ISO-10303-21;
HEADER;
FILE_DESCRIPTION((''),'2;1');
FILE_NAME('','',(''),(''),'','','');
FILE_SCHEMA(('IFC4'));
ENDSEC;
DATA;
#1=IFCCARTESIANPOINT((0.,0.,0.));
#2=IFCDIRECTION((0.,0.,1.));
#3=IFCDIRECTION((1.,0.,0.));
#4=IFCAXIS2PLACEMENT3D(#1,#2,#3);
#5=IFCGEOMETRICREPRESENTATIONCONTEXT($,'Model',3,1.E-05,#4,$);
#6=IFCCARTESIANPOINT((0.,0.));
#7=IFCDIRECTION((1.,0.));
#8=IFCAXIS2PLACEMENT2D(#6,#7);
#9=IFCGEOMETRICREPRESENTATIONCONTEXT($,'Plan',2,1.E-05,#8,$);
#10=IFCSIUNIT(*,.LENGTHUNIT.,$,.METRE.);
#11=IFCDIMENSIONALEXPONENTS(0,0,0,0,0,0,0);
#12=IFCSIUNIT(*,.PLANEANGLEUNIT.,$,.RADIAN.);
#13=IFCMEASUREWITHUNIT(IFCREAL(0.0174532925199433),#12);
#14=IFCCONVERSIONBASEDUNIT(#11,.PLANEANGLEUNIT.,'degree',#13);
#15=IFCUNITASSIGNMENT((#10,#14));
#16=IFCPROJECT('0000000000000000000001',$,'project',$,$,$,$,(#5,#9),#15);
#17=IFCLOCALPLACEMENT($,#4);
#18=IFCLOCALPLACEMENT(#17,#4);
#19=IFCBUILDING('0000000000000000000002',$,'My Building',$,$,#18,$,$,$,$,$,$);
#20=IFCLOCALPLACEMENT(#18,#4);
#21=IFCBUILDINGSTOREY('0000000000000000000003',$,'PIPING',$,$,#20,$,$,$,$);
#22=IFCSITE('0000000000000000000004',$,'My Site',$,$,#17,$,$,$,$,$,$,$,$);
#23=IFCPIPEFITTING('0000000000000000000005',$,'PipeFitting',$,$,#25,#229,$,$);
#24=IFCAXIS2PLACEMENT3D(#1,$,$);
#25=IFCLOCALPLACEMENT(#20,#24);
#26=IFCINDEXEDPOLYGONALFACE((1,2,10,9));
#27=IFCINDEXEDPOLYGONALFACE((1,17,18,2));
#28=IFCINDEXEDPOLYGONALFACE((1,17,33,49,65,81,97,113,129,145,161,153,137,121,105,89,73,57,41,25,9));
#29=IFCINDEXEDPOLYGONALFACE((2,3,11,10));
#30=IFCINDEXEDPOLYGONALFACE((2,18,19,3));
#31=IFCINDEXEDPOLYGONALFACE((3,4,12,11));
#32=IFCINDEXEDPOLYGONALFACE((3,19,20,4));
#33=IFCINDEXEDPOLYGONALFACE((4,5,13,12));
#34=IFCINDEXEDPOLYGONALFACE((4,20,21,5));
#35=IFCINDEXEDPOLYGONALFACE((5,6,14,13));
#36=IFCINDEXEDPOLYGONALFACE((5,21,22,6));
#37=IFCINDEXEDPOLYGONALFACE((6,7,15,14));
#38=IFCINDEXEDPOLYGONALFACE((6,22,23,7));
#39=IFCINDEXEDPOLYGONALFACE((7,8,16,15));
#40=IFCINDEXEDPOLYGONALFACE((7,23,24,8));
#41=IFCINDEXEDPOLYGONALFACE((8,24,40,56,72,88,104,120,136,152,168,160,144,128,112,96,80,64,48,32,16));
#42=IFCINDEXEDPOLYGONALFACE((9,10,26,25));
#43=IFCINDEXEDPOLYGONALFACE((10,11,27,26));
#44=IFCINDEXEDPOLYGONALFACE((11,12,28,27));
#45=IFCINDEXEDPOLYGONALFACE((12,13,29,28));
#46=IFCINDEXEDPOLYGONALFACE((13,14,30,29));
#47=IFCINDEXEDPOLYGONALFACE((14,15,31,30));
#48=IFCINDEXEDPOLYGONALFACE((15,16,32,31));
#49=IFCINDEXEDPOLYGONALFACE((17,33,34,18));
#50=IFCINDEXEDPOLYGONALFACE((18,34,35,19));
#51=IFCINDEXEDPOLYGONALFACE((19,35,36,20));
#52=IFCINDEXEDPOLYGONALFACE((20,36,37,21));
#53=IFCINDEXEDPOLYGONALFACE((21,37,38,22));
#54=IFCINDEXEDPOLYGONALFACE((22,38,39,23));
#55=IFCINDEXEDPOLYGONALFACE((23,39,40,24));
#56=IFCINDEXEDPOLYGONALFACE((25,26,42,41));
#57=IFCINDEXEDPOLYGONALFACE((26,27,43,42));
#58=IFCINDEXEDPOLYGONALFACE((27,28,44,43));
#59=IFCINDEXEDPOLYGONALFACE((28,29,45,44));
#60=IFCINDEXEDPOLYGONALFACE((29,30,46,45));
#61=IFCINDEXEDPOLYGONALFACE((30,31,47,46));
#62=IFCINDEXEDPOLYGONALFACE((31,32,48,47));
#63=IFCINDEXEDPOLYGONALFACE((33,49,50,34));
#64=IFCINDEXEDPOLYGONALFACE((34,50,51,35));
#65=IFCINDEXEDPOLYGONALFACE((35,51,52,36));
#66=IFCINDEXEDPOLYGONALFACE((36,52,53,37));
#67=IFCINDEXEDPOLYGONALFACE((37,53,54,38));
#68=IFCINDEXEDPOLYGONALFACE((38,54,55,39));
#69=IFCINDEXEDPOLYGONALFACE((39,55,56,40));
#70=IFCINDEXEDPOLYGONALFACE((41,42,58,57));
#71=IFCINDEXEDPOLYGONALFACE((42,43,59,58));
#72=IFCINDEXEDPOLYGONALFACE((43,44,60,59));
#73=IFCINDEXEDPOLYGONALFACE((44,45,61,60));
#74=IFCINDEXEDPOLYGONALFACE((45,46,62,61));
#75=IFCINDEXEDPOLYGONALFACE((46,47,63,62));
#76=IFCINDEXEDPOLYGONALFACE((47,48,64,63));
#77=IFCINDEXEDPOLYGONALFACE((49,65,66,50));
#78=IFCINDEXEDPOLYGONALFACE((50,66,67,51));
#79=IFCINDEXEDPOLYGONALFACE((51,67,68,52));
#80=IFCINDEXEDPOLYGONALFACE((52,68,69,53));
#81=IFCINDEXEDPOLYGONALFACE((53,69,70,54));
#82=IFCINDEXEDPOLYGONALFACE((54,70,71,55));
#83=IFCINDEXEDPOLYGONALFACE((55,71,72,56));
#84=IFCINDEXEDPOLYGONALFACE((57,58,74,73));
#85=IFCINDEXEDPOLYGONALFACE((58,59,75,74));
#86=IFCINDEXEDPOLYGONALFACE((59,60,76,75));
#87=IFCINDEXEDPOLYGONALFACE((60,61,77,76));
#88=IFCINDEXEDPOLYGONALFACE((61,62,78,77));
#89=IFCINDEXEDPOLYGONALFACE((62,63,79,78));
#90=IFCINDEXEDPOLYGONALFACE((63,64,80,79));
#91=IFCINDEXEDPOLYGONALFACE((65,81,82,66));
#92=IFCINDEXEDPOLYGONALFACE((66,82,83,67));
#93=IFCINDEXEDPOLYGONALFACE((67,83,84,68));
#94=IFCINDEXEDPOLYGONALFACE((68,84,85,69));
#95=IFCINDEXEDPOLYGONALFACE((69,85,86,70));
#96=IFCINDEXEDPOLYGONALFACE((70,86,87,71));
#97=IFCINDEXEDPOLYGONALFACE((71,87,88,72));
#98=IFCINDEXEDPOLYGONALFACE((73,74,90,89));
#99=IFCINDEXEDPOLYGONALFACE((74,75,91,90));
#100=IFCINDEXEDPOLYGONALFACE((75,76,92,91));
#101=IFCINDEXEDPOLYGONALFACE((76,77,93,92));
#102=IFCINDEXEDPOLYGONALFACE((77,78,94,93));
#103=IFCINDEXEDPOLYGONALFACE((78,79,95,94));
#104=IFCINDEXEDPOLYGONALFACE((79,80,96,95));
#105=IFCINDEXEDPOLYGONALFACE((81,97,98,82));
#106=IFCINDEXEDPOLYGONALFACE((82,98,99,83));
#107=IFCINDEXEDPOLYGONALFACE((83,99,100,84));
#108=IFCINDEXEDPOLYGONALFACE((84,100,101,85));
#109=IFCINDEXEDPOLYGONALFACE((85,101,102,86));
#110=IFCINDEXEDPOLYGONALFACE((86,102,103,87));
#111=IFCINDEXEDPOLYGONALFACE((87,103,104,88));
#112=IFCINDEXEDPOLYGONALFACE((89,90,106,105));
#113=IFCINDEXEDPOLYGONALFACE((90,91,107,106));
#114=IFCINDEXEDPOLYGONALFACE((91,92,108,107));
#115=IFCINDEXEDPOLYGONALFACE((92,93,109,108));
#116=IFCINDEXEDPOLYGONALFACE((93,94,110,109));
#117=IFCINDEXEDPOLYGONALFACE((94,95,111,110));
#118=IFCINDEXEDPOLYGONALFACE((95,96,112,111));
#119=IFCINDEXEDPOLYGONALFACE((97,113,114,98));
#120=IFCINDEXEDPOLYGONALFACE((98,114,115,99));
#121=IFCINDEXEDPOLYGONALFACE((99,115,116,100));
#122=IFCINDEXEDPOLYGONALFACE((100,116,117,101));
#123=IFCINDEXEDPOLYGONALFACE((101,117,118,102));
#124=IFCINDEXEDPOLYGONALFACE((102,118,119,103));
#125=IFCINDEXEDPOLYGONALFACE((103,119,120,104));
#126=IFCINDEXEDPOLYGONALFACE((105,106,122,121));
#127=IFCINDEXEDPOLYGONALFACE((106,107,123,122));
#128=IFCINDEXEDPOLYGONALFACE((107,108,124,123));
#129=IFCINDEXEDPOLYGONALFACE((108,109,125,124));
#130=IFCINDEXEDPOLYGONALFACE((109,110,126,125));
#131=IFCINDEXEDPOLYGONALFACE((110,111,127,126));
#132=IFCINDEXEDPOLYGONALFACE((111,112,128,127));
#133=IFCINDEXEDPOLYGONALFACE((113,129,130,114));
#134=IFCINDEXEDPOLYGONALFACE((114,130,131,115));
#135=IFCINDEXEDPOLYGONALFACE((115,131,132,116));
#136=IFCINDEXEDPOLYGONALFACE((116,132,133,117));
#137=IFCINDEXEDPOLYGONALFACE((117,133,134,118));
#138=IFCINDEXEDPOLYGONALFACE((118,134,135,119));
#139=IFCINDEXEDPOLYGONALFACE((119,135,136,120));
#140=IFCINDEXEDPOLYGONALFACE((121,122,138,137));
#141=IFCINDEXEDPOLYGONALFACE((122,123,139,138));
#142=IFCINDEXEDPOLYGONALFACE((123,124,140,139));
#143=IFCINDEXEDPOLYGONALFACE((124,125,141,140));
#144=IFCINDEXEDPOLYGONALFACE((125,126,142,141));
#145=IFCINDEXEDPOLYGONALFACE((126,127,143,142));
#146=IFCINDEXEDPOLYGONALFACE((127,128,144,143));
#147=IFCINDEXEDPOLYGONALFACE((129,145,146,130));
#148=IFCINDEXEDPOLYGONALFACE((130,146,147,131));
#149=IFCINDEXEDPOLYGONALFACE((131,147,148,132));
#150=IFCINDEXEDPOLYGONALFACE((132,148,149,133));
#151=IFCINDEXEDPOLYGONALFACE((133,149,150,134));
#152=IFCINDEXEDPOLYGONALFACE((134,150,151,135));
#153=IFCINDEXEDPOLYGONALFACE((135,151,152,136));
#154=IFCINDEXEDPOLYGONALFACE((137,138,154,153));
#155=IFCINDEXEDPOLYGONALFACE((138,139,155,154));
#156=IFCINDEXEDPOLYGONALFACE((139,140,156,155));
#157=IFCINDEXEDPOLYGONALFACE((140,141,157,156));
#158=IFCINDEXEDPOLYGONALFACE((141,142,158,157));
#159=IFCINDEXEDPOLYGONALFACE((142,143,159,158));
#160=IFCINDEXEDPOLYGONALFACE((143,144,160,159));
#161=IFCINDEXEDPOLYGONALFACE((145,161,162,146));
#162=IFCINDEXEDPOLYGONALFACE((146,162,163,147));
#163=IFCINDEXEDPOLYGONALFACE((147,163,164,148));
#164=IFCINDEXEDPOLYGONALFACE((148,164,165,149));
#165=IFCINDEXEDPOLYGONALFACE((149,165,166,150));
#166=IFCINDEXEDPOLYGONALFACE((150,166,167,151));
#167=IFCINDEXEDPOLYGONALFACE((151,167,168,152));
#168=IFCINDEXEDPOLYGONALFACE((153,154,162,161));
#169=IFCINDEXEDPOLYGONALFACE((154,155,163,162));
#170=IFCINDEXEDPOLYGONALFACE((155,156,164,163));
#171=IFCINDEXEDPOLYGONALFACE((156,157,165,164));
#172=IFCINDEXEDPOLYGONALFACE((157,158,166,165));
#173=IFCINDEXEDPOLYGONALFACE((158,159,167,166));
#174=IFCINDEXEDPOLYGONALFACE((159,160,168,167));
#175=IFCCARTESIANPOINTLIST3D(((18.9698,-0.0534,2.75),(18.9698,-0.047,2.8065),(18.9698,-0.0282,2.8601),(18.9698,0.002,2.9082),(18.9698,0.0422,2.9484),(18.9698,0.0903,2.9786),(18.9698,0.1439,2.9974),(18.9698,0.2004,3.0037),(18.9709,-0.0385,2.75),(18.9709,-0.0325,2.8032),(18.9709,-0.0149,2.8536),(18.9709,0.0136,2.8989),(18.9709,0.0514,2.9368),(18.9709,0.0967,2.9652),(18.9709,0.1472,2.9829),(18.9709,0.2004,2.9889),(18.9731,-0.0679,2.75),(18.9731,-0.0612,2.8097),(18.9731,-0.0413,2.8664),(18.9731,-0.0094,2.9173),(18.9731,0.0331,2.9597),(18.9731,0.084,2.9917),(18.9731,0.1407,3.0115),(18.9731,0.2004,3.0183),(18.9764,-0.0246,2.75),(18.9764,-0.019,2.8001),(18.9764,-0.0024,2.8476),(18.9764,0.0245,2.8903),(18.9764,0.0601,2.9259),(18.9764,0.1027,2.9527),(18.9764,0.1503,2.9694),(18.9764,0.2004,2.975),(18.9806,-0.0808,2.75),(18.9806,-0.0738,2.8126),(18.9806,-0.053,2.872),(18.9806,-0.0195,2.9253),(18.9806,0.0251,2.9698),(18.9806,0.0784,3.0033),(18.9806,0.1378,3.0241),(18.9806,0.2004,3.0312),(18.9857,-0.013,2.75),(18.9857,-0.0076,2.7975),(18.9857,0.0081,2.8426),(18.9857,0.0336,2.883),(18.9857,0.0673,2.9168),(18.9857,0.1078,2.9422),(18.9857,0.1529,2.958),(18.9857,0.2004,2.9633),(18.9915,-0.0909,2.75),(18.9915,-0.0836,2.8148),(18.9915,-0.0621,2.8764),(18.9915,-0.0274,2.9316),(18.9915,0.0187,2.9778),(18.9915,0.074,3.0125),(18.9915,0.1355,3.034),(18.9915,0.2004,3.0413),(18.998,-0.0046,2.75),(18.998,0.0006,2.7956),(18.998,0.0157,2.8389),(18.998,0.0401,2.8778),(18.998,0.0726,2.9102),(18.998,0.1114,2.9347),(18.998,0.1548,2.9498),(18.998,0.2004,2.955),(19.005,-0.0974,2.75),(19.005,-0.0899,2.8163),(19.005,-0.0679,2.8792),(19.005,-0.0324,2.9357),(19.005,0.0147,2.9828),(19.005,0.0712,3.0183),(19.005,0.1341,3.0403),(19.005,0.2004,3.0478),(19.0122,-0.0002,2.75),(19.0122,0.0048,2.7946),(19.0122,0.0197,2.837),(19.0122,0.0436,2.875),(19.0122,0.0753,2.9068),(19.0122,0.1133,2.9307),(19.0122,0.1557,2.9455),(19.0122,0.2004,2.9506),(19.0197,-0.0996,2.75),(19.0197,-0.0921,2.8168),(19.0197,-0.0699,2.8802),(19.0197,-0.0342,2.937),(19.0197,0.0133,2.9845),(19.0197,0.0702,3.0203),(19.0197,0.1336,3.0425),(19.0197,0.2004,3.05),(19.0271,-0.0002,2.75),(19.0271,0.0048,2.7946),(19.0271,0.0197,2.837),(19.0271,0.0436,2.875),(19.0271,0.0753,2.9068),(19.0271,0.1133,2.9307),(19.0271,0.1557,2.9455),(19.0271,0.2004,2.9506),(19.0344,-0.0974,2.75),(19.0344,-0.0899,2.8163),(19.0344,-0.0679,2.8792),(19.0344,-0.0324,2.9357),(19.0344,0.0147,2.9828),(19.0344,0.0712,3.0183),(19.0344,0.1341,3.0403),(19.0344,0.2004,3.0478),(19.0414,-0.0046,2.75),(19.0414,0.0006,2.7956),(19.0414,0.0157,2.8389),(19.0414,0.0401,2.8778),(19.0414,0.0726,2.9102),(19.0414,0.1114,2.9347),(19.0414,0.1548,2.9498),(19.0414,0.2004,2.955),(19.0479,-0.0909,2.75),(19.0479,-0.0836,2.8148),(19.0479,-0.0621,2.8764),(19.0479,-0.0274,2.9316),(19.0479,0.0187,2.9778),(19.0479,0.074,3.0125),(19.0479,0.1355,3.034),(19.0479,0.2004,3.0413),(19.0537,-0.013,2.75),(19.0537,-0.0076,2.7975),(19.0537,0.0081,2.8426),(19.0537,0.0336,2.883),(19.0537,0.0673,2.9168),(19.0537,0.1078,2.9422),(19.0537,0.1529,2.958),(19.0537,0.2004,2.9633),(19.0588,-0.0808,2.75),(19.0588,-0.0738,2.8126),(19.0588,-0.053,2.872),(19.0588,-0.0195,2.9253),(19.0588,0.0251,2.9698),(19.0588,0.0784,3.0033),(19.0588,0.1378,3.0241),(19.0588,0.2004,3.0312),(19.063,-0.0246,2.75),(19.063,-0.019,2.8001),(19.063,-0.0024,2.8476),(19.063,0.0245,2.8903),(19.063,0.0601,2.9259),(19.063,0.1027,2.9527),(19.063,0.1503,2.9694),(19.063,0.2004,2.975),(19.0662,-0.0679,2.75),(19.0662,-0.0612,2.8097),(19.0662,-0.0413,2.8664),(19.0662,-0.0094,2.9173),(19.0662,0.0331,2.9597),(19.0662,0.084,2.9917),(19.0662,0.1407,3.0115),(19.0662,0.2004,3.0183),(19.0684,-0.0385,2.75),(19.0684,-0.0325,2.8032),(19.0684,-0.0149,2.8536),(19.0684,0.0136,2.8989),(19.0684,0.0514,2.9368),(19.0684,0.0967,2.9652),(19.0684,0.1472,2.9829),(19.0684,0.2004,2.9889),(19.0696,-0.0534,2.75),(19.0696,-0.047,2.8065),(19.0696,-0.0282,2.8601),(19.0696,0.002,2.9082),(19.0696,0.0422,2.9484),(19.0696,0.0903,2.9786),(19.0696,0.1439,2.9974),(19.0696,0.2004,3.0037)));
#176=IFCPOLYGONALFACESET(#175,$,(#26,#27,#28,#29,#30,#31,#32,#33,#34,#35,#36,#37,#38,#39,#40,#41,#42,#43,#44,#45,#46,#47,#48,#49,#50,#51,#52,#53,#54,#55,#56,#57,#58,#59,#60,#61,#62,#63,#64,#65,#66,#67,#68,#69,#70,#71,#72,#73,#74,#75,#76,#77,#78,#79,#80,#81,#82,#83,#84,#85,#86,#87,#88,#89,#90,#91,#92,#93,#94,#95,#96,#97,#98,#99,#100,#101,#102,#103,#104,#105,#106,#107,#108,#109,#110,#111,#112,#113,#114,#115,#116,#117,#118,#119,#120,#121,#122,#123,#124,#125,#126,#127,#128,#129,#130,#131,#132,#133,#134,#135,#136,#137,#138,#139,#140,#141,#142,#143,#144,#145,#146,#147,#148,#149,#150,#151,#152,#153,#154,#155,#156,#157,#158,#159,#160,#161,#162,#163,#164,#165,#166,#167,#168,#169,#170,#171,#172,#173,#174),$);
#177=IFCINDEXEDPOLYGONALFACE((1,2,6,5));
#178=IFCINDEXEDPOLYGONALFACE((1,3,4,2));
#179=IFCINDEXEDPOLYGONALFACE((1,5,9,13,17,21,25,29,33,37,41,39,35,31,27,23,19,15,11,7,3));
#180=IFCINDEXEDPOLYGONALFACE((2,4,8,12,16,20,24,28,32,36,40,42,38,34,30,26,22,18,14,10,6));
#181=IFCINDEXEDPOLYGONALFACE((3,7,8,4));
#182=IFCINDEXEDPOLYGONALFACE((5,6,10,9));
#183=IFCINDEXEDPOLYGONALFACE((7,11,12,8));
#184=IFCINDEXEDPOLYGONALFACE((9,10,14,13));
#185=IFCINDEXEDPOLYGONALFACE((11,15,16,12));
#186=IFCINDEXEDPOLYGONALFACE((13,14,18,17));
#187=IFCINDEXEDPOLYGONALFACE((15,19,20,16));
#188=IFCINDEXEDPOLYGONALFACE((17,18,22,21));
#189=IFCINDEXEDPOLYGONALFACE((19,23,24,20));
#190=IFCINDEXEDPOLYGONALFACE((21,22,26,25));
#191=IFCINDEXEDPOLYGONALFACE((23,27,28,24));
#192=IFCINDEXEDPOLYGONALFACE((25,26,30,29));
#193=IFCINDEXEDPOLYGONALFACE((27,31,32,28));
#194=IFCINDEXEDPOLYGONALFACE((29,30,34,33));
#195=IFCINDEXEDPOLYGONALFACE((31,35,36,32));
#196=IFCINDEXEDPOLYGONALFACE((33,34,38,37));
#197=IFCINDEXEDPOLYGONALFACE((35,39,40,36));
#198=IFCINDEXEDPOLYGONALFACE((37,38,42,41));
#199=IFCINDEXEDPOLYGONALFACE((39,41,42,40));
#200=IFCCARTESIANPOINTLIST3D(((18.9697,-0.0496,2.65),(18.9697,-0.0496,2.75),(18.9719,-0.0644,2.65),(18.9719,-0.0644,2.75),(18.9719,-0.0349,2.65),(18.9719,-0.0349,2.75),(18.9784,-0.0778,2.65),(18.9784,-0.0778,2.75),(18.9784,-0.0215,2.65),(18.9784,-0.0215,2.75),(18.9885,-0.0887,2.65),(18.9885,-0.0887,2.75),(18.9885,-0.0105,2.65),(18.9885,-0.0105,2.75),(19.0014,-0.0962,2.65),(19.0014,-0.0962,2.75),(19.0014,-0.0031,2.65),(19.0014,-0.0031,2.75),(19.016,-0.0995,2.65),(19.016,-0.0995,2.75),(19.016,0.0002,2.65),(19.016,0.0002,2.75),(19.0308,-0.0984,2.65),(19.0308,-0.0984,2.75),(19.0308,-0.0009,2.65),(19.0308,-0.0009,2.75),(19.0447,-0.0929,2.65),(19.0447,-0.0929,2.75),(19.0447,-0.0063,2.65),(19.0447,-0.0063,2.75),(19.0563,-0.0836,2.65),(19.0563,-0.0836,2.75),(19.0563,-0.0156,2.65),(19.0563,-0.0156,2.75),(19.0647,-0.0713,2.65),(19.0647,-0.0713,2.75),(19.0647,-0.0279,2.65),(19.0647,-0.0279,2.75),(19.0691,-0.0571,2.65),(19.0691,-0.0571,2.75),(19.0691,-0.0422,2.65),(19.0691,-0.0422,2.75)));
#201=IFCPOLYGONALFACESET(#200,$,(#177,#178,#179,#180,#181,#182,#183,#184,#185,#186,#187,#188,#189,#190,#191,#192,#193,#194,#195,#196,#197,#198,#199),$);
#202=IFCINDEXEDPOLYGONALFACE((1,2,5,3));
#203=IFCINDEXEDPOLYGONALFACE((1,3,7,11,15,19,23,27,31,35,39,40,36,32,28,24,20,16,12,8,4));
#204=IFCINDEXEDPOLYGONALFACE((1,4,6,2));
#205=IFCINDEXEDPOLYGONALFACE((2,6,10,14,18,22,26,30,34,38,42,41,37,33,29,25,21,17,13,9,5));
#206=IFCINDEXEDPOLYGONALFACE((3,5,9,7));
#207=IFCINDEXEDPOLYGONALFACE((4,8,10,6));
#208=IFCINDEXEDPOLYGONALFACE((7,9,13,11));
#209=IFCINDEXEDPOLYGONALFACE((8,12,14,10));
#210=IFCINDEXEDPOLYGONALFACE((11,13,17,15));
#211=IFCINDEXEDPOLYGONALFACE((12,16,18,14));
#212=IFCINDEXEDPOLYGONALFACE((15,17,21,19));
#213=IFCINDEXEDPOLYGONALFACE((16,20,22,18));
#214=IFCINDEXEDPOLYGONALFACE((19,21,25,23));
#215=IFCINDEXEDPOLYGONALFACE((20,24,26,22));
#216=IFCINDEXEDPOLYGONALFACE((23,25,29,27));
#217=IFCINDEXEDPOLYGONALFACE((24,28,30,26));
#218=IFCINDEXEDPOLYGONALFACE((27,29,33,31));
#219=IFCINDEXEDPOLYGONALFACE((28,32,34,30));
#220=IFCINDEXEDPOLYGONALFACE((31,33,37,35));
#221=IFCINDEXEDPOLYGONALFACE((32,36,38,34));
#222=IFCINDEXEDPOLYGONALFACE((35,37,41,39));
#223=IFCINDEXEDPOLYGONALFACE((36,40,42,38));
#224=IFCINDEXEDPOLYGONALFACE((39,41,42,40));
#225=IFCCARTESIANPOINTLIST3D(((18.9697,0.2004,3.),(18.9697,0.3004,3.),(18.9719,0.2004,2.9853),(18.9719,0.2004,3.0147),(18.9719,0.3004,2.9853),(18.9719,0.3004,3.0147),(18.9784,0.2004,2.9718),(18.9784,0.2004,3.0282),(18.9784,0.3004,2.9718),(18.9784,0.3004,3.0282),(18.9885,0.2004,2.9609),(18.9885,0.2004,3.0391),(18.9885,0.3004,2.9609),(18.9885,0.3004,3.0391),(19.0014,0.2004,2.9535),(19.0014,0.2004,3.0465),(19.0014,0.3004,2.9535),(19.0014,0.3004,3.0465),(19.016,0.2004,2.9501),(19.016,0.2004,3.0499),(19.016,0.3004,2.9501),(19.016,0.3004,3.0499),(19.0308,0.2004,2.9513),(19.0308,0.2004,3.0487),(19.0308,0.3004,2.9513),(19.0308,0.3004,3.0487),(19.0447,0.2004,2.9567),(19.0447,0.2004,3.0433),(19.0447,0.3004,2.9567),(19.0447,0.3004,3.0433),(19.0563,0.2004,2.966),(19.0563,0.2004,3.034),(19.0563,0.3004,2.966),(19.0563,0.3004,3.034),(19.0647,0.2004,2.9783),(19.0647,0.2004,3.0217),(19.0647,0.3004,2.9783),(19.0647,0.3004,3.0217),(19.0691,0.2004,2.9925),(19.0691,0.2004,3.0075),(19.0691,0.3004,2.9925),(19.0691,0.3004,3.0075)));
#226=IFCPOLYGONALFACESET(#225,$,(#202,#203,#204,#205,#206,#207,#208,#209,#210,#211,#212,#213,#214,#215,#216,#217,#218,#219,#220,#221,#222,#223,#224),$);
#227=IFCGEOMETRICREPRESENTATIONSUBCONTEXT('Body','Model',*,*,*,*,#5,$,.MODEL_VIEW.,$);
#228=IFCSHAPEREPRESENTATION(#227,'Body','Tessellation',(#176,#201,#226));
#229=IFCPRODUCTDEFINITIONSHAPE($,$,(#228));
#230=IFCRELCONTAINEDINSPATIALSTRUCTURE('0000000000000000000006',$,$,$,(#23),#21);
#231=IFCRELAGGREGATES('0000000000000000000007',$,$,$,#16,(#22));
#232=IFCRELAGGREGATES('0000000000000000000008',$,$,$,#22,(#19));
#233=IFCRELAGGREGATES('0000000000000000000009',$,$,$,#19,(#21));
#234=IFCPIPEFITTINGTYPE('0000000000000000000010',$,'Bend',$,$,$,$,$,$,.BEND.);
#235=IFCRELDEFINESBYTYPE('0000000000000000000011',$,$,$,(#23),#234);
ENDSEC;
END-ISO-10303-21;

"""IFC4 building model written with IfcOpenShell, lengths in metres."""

from ifc_helpers import new_model, entity, si_unit, converted_unit, frame, origin_with_axes, origin_2d_with_axis, place, context, subcontext, project, spatial, circle, extrude, source, transform, mapped, type_object, type_shapes, element, save


model = new_model("IFC4")

# Units and contexts
model_context = context("Model", 3, precision=1e-05, world=origin_with_axes())
plan_context = context("Plan", 2, precision=1e-05, world=origin_2d_with_axis())
body_context = subcontext(model_context, "Body", "Model", "MODEL_VIEW")
ifc_project = project(units=[si_unit("LENGTHUNIT", "METRE"), converted_unit("PLANEANGLEUNIT", "degree", entity("IfcReal", 0.0174532925199433), si_unit("PLANEANGLEUNIT", "RADIAN"), dimensions=[0, 0, 0, 0, 0, 0, 0])], contexts=[model_context, plan_context])

# Site, building, storey
site_placement = place(None, origin_with_axes())
site = spatial("IfcSite", under=ifc_project, at=site_placement, Name="My Site")
building_placement = place(site_placement, origin_with_axes())
building = spatial("IfcBuilding", under=site, at=building_placement, Name="My Building")
storey_placement = place(building_placement, origin_with_axes())
storey = spatial("IfcBuildingStorey", under=building, at=storey_placement, Name="PIPING")

# Pipe fitting
pipe_fitting_type_1 = type_object("IfcPipeFittingType", Name="Bend", PredefinedType="BEND")
shared_shape = source(origin_with_axes(), body_context, "Body", "SolidModel", [
    entity("IfcSweptDiskSolid", entity("IfcIndexedPolyCurve", entity("IfcCartesianPointList3D", [[0.0, 0.0, -0.1], [0.0, 0.0732, -0.2768], [0.0, 0.25, -0.35]]), [entity("IfcArcIndex", [1, 2, 3])]), 0.05),
    extrude(circle(Radius=0.05), origin_with_axes(), (0.0, 0.0, -1.0), 0.1),
    extrude(circle(Radius=0.05), frame((0.0, 0.25, -0.35), z_axis=(0.0, 1.0, 0.0), x_axis=(1.0, 0.0, 0.0)), (0.0, 0.0, 1.0), 0.1),
])
type_shapes(pipe_fitting_type_1, [shared_shape])
for number, where, z_axis, x_axis, name in (
    (1, (19.0197, -0.0496, 2.65), (0.0, 0.0, -1.0), (-1.0, 0.0, 0.0), "PipeFitting"),
):
    element("IfcPipeFitting", number, at=place(storey_placement, frame(where, z_axis=z_axis, x_axis=x_axis)), inside=storey, type_object=pipe_fitting_type_1, Name=name, context=body_context, shape_type="MappedRepresentation", body=[
        mapped(shared_shape, transform((0.0, 0.0, 0.0), x_axis=(1.0, 0.0, 0.0), y_axis=(0.0, 1.0, 0.0), z_axis=(0.0, 0.0, 1.0), scale=1.0)),
    ])

save(model, "model.ifc")
